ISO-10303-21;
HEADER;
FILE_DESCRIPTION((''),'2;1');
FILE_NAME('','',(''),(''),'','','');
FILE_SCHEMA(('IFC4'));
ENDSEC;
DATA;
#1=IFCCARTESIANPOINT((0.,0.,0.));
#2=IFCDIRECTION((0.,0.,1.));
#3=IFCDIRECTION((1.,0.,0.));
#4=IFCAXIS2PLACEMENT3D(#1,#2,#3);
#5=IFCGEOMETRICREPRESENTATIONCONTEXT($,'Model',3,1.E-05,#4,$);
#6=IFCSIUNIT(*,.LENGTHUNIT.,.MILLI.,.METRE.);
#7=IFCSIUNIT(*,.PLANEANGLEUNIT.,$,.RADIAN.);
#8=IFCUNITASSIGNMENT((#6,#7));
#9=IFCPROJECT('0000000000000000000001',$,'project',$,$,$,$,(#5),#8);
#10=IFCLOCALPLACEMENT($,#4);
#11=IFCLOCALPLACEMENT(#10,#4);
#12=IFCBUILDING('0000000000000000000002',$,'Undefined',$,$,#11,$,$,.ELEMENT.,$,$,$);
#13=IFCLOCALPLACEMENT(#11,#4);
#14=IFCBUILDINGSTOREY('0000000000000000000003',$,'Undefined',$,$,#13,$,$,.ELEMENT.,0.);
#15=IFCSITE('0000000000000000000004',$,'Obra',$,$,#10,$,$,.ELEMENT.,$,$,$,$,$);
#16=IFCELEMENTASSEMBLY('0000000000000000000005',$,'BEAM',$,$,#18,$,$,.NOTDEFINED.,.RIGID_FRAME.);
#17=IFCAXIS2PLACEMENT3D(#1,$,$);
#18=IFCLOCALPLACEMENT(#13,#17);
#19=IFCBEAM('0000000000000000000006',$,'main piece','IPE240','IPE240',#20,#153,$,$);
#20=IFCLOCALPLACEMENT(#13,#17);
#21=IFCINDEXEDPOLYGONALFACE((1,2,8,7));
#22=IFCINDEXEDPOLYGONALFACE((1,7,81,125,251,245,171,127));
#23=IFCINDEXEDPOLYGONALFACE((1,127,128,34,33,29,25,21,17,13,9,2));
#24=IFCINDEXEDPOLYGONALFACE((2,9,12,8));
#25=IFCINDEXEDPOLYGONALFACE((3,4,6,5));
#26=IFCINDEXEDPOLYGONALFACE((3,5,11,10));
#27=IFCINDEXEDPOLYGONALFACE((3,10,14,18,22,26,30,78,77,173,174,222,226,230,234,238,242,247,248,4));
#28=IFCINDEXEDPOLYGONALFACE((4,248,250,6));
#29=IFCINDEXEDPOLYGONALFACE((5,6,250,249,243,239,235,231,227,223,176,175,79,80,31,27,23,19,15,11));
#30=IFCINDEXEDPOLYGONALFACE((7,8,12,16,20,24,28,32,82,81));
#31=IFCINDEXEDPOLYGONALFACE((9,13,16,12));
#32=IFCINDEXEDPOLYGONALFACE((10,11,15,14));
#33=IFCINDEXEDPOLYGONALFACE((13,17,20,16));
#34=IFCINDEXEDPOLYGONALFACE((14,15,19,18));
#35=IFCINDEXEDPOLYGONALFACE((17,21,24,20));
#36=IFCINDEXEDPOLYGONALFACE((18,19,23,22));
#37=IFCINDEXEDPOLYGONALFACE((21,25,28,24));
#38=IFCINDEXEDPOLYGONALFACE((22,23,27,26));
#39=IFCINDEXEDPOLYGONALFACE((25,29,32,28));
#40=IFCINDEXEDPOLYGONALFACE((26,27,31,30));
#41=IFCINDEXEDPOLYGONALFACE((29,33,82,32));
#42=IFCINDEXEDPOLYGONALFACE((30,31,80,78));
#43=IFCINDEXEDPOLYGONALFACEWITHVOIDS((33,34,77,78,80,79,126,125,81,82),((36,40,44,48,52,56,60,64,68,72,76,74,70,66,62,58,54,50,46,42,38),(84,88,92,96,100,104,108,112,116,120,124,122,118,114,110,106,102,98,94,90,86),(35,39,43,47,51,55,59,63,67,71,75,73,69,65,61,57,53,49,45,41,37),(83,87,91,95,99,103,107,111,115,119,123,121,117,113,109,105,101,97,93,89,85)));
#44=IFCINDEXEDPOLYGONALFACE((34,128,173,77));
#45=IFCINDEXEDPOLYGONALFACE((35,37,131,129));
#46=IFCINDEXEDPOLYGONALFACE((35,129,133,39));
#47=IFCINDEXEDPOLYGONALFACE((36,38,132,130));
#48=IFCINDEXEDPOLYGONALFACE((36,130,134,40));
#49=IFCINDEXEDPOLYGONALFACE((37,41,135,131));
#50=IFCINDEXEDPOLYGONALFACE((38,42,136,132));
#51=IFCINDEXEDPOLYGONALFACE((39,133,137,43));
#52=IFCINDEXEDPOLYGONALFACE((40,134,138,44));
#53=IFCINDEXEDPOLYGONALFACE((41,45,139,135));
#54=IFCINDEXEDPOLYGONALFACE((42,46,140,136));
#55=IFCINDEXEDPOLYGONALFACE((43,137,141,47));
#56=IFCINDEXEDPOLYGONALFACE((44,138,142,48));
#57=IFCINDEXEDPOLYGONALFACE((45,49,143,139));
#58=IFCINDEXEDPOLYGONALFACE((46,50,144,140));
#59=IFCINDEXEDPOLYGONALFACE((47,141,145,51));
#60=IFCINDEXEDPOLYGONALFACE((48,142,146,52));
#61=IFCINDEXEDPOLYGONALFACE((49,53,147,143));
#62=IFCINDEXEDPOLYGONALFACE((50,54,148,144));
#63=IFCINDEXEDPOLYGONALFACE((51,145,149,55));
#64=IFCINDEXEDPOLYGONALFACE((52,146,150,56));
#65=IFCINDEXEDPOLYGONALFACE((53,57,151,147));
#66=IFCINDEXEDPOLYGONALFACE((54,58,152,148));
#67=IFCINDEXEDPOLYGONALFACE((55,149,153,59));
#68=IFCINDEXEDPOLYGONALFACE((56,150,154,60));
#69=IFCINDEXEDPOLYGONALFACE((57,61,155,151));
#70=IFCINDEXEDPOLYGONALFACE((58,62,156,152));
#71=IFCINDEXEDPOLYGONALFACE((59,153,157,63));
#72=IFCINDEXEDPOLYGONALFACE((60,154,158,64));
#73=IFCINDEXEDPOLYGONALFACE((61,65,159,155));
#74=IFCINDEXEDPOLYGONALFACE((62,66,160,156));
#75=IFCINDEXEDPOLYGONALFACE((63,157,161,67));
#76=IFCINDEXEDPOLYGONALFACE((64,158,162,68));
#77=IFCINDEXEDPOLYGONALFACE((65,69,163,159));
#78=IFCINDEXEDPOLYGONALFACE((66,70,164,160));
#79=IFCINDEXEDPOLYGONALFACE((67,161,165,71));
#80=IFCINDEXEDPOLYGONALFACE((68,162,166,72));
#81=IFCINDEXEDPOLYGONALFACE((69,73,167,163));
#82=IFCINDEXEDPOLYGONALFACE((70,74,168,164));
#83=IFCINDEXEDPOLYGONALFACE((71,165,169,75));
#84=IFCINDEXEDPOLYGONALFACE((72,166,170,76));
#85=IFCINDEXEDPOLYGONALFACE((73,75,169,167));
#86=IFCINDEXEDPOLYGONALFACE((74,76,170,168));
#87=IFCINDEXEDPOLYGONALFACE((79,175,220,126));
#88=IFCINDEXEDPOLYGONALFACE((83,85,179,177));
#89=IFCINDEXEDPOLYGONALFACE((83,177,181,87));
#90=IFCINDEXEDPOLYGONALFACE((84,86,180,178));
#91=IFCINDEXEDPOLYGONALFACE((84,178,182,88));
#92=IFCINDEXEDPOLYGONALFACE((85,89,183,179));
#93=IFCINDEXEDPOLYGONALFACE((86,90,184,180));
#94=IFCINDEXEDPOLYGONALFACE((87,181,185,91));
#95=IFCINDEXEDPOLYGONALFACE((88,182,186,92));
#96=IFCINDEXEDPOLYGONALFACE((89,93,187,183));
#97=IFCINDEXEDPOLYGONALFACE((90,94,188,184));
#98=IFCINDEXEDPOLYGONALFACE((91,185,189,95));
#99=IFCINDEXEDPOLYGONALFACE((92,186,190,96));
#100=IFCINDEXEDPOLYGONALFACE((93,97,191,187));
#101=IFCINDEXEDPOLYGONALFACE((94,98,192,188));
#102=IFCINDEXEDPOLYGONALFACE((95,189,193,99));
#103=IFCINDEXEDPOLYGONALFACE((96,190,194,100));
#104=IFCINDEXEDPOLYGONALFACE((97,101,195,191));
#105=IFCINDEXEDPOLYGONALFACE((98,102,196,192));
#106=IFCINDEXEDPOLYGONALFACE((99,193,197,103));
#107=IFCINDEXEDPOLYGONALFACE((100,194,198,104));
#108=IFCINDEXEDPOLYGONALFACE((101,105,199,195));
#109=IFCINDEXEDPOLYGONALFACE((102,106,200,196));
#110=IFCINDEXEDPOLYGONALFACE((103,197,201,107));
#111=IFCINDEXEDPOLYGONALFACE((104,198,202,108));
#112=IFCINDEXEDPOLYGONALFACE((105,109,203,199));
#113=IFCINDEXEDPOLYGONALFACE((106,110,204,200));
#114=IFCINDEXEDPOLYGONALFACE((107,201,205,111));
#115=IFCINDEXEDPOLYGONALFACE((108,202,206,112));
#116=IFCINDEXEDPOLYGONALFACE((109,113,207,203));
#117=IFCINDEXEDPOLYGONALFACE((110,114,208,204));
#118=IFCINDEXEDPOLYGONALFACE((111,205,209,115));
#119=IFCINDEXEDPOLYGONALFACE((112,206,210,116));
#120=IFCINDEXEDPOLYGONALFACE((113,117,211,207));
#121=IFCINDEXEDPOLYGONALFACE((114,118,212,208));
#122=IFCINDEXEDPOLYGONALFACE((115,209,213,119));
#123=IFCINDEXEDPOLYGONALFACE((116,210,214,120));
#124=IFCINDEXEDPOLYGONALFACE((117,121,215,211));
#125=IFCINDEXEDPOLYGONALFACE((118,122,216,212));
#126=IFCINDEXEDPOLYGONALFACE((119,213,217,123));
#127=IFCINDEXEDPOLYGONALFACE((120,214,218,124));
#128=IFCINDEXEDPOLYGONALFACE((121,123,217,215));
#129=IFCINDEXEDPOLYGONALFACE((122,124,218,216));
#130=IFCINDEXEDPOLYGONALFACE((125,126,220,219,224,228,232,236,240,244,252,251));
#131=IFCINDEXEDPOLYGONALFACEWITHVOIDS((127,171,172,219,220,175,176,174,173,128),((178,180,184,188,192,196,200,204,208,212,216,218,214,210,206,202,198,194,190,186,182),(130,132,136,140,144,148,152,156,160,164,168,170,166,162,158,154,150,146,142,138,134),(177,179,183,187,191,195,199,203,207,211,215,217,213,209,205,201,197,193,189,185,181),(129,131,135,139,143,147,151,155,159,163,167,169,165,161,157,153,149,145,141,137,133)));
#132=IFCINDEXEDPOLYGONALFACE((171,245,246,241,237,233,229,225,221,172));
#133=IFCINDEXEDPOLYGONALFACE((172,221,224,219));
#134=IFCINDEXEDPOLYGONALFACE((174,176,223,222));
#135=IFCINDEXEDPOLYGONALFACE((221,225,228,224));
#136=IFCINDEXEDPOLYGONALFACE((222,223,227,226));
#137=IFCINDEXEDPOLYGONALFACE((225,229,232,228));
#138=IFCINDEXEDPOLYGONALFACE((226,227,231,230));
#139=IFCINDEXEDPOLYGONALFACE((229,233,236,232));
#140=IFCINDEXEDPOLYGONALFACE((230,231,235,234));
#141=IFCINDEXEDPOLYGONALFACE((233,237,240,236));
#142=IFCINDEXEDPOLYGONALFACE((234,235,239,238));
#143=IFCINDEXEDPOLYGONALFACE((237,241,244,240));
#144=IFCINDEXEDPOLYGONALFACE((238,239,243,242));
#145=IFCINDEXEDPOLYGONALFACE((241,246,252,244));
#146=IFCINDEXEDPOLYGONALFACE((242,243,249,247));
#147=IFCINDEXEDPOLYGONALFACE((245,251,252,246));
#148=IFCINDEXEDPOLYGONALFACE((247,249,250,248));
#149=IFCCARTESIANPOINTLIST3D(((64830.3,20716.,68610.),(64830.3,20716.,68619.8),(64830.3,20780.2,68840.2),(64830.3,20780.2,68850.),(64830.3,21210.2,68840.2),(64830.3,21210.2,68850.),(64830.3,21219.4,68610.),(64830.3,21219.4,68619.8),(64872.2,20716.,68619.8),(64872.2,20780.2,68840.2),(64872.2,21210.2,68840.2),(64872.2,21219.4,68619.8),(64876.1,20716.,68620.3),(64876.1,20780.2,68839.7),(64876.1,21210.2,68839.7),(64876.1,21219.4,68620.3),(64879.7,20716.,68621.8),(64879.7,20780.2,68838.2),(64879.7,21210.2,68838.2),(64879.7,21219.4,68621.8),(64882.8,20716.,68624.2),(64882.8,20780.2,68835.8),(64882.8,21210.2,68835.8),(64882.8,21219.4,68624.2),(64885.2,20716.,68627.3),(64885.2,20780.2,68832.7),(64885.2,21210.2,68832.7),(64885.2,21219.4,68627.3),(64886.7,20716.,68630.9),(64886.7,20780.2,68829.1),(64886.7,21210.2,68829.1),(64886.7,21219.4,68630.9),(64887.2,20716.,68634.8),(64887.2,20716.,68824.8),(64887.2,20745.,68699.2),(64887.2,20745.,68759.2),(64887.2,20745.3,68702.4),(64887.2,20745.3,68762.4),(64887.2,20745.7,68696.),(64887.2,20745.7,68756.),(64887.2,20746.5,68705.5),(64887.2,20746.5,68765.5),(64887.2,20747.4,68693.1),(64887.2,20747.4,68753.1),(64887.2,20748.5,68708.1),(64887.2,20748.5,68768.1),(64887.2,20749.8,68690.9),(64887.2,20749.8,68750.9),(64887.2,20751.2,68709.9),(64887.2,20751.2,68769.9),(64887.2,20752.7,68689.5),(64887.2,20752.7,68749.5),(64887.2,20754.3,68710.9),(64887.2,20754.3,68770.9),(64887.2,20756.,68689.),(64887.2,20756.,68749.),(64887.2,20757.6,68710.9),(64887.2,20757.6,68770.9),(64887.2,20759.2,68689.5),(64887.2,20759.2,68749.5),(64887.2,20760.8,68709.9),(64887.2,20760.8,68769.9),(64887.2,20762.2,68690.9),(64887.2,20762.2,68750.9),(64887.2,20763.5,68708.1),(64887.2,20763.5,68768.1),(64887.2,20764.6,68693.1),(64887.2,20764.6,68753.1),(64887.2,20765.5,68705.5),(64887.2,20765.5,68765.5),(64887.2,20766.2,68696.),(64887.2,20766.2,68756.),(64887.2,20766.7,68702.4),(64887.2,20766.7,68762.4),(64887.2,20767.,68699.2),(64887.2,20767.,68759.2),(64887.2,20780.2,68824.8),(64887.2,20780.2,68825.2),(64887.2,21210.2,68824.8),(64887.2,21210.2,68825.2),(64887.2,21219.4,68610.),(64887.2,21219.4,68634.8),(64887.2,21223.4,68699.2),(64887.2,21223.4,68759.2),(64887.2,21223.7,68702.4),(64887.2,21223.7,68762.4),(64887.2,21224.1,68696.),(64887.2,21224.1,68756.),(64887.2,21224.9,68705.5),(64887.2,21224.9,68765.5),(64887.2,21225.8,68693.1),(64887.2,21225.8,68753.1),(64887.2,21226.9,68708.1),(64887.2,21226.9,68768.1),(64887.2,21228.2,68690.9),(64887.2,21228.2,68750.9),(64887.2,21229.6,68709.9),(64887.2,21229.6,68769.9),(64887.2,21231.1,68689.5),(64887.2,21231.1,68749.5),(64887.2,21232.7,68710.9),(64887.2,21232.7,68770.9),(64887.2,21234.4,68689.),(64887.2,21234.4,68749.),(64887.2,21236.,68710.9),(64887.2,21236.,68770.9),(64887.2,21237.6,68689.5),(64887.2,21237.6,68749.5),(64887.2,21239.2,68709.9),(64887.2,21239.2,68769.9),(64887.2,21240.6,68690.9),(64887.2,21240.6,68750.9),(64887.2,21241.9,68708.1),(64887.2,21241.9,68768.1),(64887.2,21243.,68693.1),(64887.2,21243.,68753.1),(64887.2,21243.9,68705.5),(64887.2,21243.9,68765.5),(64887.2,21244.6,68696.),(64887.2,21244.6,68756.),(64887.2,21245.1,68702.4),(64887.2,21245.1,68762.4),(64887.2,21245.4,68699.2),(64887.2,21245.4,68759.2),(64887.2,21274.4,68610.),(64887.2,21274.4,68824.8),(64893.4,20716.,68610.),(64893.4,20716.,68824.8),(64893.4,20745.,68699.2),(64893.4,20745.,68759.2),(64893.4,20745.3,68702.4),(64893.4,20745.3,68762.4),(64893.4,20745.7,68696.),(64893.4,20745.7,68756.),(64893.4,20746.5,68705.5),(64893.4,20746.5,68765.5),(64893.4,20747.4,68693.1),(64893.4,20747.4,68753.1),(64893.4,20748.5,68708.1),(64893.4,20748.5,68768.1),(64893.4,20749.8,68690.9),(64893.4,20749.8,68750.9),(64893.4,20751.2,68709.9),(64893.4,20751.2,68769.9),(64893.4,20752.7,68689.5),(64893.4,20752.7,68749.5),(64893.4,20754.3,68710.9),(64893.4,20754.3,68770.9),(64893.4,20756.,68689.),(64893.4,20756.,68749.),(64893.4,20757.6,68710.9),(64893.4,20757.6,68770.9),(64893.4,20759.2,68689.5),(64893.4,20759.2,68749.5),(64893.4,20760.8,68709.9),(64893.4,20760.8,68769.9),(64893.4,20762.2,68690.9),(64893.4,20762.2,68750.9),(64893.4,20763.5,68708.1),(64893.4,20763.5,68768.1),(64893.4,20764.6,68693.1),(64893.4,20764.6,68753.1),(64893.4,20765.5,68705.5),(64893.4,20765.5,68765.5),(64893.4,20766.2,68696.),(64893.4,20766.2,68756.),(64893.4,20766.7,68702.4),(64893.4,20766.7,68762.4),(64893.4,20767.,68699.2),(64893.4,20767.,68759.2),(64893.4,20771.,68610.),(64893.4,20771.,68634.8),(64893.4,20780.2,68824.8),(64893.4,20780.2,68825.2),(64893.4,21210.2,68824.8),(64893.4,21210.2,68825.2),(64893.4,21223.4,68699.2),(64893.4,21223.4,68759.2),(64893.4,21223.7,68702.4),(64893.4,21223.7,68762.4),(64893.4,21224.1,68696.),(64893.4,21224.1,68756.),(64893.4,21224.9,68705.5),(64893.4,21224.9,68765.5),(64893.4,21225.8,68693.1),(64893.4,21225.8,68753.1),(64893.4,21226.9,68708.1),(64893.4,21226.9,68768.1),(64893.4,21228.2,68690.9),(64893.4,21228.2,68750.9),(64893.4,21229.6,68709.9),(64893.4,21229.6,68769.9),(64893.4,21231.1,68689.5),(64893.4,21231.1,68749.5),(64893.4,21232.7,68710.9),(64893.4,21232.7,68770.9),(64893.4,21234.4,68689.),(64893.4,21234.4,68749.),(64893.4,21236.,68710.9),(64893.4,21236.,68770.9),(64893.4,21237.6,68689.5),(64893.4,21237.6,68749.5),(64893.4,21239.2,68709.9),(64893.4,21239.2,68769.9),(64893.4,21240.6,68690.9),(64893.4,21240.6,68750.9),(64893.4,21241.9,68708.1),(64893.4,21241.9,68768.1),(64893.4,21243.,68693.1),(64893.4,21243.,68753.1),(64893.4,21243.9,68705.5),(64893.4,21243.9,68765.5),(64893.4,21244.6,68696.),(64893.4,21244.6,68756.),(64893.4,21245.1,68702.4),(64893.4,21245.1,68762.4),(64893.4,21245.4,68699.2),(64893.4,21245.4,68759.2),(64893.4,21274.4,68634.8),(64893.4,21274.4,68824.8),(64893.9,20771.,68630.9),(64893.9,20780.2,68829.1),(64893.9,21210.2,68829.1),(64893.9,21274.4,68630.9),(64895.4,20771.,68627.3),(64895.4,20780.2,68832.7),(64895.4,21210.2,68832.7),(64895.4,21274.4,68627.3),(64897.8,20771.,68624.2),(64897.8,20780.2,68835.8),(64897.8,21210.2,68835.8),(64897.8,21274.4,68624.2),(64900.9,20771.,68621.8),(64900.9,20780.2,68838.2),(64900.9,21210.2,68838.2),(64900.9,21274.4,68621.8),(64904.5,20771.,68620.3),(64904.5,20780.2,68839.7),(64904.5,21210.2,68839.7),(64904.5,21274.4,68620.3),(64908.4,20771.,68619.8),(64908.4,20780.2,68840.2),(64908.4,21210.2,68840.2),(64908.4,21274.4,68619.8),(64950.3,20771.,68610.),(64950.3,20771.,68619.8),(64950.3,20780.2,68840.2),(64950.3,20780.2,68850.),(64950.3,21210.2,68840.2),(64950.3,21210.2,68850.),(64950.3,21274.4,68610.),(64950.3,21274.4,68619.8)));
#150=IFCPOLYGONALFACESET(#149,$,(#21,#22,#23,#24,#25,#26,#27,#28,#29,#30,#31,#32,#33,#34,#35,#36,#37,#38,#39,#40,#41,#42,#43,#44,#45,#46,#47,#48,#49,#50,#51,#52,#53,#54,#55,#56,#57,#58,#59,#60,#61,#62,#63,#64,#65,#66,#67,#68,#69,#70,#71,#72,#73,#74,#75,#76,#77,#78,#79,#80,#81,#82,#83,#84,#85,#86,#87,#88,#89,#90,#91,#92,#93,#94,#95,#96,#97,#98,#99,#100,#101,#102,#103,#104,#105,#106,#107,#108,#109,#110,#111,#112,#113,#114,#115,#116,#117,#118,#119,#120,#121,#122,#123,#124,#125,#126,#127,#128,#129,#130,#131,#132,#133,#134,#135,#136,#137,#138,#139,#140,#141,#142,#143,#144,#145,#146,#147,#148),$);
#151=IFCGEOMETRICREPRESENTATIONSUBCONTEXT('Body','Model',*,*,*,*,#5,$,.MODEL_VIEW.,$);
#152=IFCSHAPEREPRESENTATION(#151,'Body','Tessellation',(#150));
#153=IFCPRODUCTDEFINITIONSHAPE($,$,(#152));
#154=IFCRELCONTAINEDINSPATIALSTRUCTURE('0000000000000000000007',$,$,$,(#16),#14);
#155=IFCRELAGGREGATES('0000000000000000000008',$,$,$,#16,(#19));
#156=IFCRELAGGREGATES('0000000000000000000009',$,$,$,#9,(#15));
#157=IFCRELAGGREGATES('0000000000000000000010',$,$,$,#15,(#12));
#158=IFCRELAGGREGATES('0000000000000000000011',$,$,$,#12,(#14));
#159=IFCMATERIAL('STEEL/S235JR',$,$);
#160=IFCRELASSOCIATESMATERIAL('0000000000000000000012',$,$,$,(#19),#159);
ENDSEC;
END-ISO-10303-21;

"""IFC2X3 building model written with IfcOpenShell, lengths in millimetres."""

from ifc_helpers import new_model, si_unit, frame, origin_with_axes, origin_2d_with_axis, place, context, subcontext, project, spatial, rectangle, circle, i_section, extrude, clip, halfspace, source, transform, mapped, material, element, aggregate, save


model = new_model("IFC2X3")

# Units and contexts
model_context = context("Model", 3, precision=1e-05, world=origin_with_axes())
body_context = subcontext(model_context, "Body", "Model", "MODEL_VIEW")
ifc_project = project(units=[si_unit("LENGTHUNIT", "METRE", prefix="MILLI"), si_unit("PLANEANGLEUNIT", "RADIAN")], contexts=[model_context])

# Site, building, storey
site_placement = place(None, origin_with_axes())
site = spatial("IfcSite", under=ifc_project, at=site_placement, Name="Obra", CompositionType="ELEMENT")
building_placement = place(site_placement, origin_with_axes())
building = spatial("IfcBuilding", under=site, at=building_placement, Name="Undefined", CompositionType="ELEMENT")
storey_placement = place(building_placement, origin_with_axes())
storey = spatial("IfcBuildingStorey", under=building, at=storey_placement, Name="Undefined", CompositionType="ELEMENT", Elevation=0.0)

# Shared definitions
ifc_material_1 = material(Name="STEEL/S235JR")

# Element assembly, beam, openings
shared_shape_1 = source(origin_with_axes(), body_context, "Body", "SweptSolid", [
    extrude(circle(Radius=11.0, at=origin_2d_with_axis()), frame((0.0, -3.2, 0.0), z_axis=(0.0, 1.0, 0.0), x_axis=(1.0, 0.0, 0.0)), (0.0, 0.0, 1.0), 6.4),
])
assembly_1_placement = place(storey_placement, origin_with_axes())
assembly_1 = element("IfcElementAssembly", 1, at=assembly_1_placement, inside=storey, Name="BEAM", AssemblyPlace="NOTDEFINED", PredefinedType="RIGID_FRAME")
beam_1_placement = place(assembly_1_placement, frame((64890.3, 20782.9, 68730.0), z_axis=(0.0, 0.0, 1.0), x_axis=(0.0, 1.0, 0.0)))
beam_1 = element("IfcBeam", 2, at=beam_1_placement, material=ifc_material_1, Name="main piece", Description="IPE240", ObjectType="IPE240", context=body_context, shape_type="Clipping", body=[
    clip(clip(extrude(i_section(OverallWidth=120.0, OverallDepth=240.0, WebThickness=6.2, FlangeThickness=9.8, FilletRadius=15.0, at=origin_2d_with_axis()), frame((491.5, 0.0, 0.0), z_axis=(-1.0, 0.0, 0.0), x_axis=(0.0, -1.0, 0.0)), (0.0, 0.0, 1.0), 558.4), halfspace(frame((491.5, 0.0, -220.0), z_axis=(-1.0, -0.000002, 0.0), x_axis=(-0.000002, 1.0, 0.0)), True)), halfspace(frame((-66.9, 0.0, -220.0), z_axis=(1.0, 0.000001, 0.0), x_axis=(0.000002, -1.0, 0.0)), True)),
])
opening_1_placement = place(assembly_1_placement, frame((64890.3, 20782.9, 68730.0), z_axis=(0.0, 0.0, 1.0), x_axis=(0.0, 1.0, 0.0)))
element("IfcOpeningElement", 3, at=opening_1_placement, cuts=beam_1, ObjectType="Recess", context=body_context, shape_type="SweptSolid", body=[
    extrude(rectangle(XDim=65.0, YDim=300.0, at=origin_2d_with_axis()), frame((-44.4, -153.1, 109.8), z_axis=(0.0, 0.0, -1.0), x_axis=(1.0, 0.000001, 0.0)), (0.0, 0.0, 1.0), 249.6),
])
opening_2_placement = place(assembly_1_placement, frame((64890.3, 20782.9, 68730.0), z_axis=(0.0, 0.0, 1.0), x_axis=(0.0, 1.0, 0.0)))
element("IfcOpeningElement", 4, at=opening_2_placement, cuts=beam_1, ObjectType="Recess", context=body_context, shape_type="SweptSolid", body=[
    extrude(rectangle(XDim=26.2, YDim=76.2, at=origin_2d_with_axis()), frame((-40.8, -61.0, 107.9), z_axis=(-0.000002, 1.0, 0.0), x_axis=(0.0, 0.0, -1.0)), (0.0, 0.0, 1.0), 122.0),
])
opening_3_placement = place(assembly_1_placement, frame((64890.3, 20782.9, 68730.0), z_axis=(0.0, 0.0, 1.0), x_axis=(0.0, 1.0, 0.0)))
element("IfcOpeningElement", 5, at=opening_3_placement, cuts=beam_1, ObjectType="Recess", context=body_context, shape_type="SweptSolid", body=[
    extrude(rectangle(XDim=65.0, YDim=300.0, at=origin_2d_with_axis()), frame((468.9, 153.1, 109.8), z_axis=(0.0, 0.0, -1.0), x_axis=(-1.0, -0.000002, 0.0)), (0.0, 0.0, 1.0), 249.6),
])
opening_4_placement = place(assembly_1_placement, frame((64890.3, 20782.9, 68730.0), z_axis=(0.0, 0.0, 1.0), x_axis=(0.0, 1.0, 0.0)))
element("IfcOpeningElement", 6, at=opening_4_placement, cuts=beam_1, ObjectType="Recess", context=body_context, shape_type="SweptSolid", body=[
    extrude(rectangle(XDim=26.2, YDim=76.2, at=origin_2d_with_axis()), frame((465.4, 61.0, 107.9), z_axis=(0.000002, -1.0, 0.0), x_axis=(0.0, 0.0, -1.0)), (0.0, 0.0, 1.0), 122.0),
])
opening_5_placement = place(assembly_1_placement, frame((64890.3, 20716.0, 68850.0), z_axis=(-0.000002, 1.0, 0.0), x_axis=(0.0, 0.0, -1.0)))
element("IfcOpeningElement", 7, at=opening_5_placement, cuts=beam_1, ObjectType="Opening", context=body_context, shape_type="MappedRepresentation", body=[
    mapped(shared_shape_1, transform((90.0, 0.0, 40.0))),
    mapped(shared_shape_1, transform((150.0, 0.0, 40.0))),
])
opening_6_placement = place(assembly_1_placement, frame((64890.3, 21274.4, 68850.0), z_axis=(0.000002, -1.0, 0.0), x_axis=(0.0, 0.0, -1.0)))
element("IfcOpeningElement", 8, at=opening_6_placement, cuts=beam_1, ObjectType="Opening", context=body_context, shape_type="MappedRepresentation", body=[
    mapped(shared_shape_1, transform((90.0, 0.0, 40.0))),
    mapped(shared_shape_1, transform((150.0, 0.0, 40.0))),
])
aggregate(assembly_1, [beam_1])

save(model, "model.ifc")
